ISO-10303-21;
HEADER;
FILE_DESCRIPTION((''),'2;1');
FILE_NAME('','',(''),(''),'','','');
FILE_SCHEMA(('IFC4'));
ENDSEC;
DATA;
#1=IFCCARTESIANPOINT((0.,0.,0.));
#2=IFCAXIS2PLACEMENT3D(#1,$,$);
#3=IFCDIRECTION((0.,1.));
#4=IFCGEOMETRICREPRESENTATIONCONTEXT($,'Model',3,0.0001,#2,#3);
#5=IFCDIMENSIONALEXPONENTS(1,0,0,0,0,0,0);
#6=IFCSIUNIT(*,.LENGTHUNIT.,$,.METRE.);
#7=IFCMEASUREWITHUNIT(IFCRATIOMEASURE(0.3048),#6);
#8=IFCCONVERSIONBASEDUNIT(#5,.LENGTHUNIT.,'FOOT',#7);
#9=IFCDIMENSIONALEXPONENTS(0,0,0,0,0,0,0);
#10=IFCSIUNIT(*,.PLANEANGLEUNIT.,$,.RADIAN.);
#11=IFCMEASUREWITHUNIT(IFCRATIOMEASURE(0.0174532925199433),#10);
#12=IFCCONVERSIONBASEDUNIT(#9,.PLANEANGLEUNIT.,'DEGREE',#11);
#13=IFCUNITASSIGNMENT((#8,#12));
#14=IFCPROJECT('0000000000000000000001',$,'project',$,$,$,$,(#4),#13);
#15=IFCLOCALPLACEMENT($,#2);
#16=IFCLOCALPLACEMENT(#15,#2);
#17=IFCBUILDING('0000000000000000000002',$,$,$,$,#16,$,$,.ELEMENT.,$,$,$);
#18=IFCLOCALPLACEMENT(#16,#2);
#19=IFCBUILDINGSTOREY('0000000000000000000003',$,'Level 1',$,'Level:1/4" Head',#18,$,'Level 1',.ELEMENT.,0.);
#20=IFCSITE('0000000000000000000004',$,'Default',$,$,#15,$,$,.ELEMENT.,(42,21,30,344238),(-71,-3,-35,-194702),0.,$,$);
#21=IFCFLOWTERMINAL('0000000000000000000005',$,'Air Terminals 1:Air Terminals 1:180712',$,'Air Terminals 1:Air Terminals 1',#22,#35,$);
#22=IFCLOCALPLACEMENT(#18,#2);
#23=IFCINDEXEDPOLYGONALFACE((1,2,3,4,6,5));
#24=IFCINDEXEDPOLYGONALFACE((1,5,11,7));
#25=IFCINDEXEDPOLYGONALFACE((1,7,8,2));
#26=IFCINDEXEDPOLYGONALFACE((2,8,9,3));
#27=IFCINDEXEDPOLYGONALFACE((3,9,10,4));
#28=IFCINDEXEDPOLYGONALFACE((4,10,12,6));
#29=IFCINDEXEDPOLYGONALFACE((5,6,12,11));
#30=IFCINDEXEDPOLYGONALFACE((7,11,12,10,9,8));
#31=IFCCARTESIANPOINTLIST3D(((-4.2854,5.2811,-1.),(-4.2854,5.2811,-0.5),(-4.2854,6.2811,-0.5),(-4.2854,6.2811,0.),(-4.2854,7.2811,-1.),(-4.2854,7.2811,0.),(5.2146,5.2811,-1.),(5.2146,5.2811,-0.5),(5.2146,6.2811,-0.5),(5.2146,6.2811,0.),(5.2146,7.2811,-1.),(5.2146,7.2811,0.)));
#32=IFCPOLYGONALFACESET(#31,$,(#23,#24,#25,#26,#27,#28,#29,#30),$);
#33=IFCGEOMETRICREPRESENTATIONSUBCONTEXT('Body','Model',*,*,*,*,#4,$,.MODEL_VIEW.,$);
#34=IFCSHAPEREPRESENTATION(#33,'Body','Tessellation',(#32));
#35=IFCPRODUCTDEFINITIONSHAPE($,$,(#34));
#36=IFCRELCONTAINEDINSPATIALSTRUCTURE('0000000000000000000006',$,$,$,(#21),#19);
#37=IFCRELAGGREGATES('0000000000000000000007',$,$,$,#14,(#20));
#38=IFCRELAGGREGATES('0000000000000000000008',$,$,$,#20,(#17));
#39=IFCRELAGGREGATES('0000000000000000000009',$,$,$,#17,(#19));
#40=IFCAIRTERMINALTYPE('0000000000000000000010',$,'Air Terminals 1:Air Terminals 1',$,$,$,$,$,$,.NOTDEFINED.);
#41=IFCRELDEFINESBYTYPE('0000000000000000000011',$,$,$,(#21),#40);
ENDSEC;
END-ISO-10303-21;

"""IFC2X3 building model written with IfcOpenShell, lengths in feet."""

from ifc_helpers import new_model, entity, si_unit, converted_unit, direction, frame, origin, place, context, subcontext, project, spatial, polyline, outline, extrude, source, transform, mapped, type_object, type_shapes, element, save


model = new_model("IFC2X3")

# Units and contexts
model_context = context("Model", 3, precision=0.0001, world=origin(), true_north=direction((0.0, 1.0)))
body_context = subcontext(model_context, "Body", "Model", "MODEL_VIEW")
ifc_project = project(units=[converted_unit("LENGTHUNIT", "FOOT", entity("IfcRatioMeasure", 0.3048), si_unit("LENGTHUNIT", "METRE"), dimensions=[1, 0, 0, 0, 0, 0, 0]), converted_unit("PLANEANGLEUNIT", "DEGREE", entity("IfcRatioMeasure", 0.0174532925199433), si_unit("PLANEANGLEUNIT", "RADIAN"), dimensions=[0, 0, 0, 0, 0, 0, 0])], contexts=[model_context])

# Site, building, storey
site_placement = place(None, origin())
site = spatial("IfcSite", under=ifc_project, at=site_placement, Name="Default", CompositionType="ELEMENT", RefLatitude=(42, 21, 30, 344238), RefLongitude=(-71, -3, -35, -194702), RefElevation=0.0)
building_placement = place(site_placement, origin())
building = spatial("IfcBuilding", under=site, at=building_placement, CompositionType="ELEMENT")
storey_placement = place(building_placement, origin())
storey = spatial("IfcBuildingStorey", under=building, at=storey_placement, Name="Level 1", ObjectType="Level:1/4\" Head", LongName="Level 1", CompositionType="ELEMENT", Elevation=0.0)

# Flow terminal
air_terminal_type_1 = type_object("IfcAirTerminalType", Name="Air Terminals 1:Air Terminals 1", PredefinedType="NOTDEFINED")
shared_shape_1 = source(origin(), body_context, "Body", "SweptSolid", [
    extrude(outline(polyline([(-1.0, -0.5), (1.0, -0.5), (1.0, 0.5), (0.0, 0.5), (0.0, 0.0), (-1.0, 0.0), (-1.0, -0.5)])), frame((-4.2854, 6.2811, -0.5), z_axis=(1.0, 0.0, 0.0), x_axis=(0.0, 1.0, 0.0)), (0.0, 0.0, 1.0), 9.5),
])
type_shapes(air_terminal_type_1, [shared_shape_1])
flow_terminal_1_placement = place(storey_placement, origin())
element("IfcFlowTerminal", 1, at=flow_terminal_1_placement, inside=storey, type_object=air_terminal_type_1, Name="Air Terminals 1:Air Terminals 1:180712", ObjectType="Air Terminals 1:Air Terminals 1", context=body_context, shape_type="MappedRepresentation", body=[
    mapped(shared_shape_1, transform((0.0, 0.0, 0.0), scale=1.0)),
])

save(model, "model.ifc")
